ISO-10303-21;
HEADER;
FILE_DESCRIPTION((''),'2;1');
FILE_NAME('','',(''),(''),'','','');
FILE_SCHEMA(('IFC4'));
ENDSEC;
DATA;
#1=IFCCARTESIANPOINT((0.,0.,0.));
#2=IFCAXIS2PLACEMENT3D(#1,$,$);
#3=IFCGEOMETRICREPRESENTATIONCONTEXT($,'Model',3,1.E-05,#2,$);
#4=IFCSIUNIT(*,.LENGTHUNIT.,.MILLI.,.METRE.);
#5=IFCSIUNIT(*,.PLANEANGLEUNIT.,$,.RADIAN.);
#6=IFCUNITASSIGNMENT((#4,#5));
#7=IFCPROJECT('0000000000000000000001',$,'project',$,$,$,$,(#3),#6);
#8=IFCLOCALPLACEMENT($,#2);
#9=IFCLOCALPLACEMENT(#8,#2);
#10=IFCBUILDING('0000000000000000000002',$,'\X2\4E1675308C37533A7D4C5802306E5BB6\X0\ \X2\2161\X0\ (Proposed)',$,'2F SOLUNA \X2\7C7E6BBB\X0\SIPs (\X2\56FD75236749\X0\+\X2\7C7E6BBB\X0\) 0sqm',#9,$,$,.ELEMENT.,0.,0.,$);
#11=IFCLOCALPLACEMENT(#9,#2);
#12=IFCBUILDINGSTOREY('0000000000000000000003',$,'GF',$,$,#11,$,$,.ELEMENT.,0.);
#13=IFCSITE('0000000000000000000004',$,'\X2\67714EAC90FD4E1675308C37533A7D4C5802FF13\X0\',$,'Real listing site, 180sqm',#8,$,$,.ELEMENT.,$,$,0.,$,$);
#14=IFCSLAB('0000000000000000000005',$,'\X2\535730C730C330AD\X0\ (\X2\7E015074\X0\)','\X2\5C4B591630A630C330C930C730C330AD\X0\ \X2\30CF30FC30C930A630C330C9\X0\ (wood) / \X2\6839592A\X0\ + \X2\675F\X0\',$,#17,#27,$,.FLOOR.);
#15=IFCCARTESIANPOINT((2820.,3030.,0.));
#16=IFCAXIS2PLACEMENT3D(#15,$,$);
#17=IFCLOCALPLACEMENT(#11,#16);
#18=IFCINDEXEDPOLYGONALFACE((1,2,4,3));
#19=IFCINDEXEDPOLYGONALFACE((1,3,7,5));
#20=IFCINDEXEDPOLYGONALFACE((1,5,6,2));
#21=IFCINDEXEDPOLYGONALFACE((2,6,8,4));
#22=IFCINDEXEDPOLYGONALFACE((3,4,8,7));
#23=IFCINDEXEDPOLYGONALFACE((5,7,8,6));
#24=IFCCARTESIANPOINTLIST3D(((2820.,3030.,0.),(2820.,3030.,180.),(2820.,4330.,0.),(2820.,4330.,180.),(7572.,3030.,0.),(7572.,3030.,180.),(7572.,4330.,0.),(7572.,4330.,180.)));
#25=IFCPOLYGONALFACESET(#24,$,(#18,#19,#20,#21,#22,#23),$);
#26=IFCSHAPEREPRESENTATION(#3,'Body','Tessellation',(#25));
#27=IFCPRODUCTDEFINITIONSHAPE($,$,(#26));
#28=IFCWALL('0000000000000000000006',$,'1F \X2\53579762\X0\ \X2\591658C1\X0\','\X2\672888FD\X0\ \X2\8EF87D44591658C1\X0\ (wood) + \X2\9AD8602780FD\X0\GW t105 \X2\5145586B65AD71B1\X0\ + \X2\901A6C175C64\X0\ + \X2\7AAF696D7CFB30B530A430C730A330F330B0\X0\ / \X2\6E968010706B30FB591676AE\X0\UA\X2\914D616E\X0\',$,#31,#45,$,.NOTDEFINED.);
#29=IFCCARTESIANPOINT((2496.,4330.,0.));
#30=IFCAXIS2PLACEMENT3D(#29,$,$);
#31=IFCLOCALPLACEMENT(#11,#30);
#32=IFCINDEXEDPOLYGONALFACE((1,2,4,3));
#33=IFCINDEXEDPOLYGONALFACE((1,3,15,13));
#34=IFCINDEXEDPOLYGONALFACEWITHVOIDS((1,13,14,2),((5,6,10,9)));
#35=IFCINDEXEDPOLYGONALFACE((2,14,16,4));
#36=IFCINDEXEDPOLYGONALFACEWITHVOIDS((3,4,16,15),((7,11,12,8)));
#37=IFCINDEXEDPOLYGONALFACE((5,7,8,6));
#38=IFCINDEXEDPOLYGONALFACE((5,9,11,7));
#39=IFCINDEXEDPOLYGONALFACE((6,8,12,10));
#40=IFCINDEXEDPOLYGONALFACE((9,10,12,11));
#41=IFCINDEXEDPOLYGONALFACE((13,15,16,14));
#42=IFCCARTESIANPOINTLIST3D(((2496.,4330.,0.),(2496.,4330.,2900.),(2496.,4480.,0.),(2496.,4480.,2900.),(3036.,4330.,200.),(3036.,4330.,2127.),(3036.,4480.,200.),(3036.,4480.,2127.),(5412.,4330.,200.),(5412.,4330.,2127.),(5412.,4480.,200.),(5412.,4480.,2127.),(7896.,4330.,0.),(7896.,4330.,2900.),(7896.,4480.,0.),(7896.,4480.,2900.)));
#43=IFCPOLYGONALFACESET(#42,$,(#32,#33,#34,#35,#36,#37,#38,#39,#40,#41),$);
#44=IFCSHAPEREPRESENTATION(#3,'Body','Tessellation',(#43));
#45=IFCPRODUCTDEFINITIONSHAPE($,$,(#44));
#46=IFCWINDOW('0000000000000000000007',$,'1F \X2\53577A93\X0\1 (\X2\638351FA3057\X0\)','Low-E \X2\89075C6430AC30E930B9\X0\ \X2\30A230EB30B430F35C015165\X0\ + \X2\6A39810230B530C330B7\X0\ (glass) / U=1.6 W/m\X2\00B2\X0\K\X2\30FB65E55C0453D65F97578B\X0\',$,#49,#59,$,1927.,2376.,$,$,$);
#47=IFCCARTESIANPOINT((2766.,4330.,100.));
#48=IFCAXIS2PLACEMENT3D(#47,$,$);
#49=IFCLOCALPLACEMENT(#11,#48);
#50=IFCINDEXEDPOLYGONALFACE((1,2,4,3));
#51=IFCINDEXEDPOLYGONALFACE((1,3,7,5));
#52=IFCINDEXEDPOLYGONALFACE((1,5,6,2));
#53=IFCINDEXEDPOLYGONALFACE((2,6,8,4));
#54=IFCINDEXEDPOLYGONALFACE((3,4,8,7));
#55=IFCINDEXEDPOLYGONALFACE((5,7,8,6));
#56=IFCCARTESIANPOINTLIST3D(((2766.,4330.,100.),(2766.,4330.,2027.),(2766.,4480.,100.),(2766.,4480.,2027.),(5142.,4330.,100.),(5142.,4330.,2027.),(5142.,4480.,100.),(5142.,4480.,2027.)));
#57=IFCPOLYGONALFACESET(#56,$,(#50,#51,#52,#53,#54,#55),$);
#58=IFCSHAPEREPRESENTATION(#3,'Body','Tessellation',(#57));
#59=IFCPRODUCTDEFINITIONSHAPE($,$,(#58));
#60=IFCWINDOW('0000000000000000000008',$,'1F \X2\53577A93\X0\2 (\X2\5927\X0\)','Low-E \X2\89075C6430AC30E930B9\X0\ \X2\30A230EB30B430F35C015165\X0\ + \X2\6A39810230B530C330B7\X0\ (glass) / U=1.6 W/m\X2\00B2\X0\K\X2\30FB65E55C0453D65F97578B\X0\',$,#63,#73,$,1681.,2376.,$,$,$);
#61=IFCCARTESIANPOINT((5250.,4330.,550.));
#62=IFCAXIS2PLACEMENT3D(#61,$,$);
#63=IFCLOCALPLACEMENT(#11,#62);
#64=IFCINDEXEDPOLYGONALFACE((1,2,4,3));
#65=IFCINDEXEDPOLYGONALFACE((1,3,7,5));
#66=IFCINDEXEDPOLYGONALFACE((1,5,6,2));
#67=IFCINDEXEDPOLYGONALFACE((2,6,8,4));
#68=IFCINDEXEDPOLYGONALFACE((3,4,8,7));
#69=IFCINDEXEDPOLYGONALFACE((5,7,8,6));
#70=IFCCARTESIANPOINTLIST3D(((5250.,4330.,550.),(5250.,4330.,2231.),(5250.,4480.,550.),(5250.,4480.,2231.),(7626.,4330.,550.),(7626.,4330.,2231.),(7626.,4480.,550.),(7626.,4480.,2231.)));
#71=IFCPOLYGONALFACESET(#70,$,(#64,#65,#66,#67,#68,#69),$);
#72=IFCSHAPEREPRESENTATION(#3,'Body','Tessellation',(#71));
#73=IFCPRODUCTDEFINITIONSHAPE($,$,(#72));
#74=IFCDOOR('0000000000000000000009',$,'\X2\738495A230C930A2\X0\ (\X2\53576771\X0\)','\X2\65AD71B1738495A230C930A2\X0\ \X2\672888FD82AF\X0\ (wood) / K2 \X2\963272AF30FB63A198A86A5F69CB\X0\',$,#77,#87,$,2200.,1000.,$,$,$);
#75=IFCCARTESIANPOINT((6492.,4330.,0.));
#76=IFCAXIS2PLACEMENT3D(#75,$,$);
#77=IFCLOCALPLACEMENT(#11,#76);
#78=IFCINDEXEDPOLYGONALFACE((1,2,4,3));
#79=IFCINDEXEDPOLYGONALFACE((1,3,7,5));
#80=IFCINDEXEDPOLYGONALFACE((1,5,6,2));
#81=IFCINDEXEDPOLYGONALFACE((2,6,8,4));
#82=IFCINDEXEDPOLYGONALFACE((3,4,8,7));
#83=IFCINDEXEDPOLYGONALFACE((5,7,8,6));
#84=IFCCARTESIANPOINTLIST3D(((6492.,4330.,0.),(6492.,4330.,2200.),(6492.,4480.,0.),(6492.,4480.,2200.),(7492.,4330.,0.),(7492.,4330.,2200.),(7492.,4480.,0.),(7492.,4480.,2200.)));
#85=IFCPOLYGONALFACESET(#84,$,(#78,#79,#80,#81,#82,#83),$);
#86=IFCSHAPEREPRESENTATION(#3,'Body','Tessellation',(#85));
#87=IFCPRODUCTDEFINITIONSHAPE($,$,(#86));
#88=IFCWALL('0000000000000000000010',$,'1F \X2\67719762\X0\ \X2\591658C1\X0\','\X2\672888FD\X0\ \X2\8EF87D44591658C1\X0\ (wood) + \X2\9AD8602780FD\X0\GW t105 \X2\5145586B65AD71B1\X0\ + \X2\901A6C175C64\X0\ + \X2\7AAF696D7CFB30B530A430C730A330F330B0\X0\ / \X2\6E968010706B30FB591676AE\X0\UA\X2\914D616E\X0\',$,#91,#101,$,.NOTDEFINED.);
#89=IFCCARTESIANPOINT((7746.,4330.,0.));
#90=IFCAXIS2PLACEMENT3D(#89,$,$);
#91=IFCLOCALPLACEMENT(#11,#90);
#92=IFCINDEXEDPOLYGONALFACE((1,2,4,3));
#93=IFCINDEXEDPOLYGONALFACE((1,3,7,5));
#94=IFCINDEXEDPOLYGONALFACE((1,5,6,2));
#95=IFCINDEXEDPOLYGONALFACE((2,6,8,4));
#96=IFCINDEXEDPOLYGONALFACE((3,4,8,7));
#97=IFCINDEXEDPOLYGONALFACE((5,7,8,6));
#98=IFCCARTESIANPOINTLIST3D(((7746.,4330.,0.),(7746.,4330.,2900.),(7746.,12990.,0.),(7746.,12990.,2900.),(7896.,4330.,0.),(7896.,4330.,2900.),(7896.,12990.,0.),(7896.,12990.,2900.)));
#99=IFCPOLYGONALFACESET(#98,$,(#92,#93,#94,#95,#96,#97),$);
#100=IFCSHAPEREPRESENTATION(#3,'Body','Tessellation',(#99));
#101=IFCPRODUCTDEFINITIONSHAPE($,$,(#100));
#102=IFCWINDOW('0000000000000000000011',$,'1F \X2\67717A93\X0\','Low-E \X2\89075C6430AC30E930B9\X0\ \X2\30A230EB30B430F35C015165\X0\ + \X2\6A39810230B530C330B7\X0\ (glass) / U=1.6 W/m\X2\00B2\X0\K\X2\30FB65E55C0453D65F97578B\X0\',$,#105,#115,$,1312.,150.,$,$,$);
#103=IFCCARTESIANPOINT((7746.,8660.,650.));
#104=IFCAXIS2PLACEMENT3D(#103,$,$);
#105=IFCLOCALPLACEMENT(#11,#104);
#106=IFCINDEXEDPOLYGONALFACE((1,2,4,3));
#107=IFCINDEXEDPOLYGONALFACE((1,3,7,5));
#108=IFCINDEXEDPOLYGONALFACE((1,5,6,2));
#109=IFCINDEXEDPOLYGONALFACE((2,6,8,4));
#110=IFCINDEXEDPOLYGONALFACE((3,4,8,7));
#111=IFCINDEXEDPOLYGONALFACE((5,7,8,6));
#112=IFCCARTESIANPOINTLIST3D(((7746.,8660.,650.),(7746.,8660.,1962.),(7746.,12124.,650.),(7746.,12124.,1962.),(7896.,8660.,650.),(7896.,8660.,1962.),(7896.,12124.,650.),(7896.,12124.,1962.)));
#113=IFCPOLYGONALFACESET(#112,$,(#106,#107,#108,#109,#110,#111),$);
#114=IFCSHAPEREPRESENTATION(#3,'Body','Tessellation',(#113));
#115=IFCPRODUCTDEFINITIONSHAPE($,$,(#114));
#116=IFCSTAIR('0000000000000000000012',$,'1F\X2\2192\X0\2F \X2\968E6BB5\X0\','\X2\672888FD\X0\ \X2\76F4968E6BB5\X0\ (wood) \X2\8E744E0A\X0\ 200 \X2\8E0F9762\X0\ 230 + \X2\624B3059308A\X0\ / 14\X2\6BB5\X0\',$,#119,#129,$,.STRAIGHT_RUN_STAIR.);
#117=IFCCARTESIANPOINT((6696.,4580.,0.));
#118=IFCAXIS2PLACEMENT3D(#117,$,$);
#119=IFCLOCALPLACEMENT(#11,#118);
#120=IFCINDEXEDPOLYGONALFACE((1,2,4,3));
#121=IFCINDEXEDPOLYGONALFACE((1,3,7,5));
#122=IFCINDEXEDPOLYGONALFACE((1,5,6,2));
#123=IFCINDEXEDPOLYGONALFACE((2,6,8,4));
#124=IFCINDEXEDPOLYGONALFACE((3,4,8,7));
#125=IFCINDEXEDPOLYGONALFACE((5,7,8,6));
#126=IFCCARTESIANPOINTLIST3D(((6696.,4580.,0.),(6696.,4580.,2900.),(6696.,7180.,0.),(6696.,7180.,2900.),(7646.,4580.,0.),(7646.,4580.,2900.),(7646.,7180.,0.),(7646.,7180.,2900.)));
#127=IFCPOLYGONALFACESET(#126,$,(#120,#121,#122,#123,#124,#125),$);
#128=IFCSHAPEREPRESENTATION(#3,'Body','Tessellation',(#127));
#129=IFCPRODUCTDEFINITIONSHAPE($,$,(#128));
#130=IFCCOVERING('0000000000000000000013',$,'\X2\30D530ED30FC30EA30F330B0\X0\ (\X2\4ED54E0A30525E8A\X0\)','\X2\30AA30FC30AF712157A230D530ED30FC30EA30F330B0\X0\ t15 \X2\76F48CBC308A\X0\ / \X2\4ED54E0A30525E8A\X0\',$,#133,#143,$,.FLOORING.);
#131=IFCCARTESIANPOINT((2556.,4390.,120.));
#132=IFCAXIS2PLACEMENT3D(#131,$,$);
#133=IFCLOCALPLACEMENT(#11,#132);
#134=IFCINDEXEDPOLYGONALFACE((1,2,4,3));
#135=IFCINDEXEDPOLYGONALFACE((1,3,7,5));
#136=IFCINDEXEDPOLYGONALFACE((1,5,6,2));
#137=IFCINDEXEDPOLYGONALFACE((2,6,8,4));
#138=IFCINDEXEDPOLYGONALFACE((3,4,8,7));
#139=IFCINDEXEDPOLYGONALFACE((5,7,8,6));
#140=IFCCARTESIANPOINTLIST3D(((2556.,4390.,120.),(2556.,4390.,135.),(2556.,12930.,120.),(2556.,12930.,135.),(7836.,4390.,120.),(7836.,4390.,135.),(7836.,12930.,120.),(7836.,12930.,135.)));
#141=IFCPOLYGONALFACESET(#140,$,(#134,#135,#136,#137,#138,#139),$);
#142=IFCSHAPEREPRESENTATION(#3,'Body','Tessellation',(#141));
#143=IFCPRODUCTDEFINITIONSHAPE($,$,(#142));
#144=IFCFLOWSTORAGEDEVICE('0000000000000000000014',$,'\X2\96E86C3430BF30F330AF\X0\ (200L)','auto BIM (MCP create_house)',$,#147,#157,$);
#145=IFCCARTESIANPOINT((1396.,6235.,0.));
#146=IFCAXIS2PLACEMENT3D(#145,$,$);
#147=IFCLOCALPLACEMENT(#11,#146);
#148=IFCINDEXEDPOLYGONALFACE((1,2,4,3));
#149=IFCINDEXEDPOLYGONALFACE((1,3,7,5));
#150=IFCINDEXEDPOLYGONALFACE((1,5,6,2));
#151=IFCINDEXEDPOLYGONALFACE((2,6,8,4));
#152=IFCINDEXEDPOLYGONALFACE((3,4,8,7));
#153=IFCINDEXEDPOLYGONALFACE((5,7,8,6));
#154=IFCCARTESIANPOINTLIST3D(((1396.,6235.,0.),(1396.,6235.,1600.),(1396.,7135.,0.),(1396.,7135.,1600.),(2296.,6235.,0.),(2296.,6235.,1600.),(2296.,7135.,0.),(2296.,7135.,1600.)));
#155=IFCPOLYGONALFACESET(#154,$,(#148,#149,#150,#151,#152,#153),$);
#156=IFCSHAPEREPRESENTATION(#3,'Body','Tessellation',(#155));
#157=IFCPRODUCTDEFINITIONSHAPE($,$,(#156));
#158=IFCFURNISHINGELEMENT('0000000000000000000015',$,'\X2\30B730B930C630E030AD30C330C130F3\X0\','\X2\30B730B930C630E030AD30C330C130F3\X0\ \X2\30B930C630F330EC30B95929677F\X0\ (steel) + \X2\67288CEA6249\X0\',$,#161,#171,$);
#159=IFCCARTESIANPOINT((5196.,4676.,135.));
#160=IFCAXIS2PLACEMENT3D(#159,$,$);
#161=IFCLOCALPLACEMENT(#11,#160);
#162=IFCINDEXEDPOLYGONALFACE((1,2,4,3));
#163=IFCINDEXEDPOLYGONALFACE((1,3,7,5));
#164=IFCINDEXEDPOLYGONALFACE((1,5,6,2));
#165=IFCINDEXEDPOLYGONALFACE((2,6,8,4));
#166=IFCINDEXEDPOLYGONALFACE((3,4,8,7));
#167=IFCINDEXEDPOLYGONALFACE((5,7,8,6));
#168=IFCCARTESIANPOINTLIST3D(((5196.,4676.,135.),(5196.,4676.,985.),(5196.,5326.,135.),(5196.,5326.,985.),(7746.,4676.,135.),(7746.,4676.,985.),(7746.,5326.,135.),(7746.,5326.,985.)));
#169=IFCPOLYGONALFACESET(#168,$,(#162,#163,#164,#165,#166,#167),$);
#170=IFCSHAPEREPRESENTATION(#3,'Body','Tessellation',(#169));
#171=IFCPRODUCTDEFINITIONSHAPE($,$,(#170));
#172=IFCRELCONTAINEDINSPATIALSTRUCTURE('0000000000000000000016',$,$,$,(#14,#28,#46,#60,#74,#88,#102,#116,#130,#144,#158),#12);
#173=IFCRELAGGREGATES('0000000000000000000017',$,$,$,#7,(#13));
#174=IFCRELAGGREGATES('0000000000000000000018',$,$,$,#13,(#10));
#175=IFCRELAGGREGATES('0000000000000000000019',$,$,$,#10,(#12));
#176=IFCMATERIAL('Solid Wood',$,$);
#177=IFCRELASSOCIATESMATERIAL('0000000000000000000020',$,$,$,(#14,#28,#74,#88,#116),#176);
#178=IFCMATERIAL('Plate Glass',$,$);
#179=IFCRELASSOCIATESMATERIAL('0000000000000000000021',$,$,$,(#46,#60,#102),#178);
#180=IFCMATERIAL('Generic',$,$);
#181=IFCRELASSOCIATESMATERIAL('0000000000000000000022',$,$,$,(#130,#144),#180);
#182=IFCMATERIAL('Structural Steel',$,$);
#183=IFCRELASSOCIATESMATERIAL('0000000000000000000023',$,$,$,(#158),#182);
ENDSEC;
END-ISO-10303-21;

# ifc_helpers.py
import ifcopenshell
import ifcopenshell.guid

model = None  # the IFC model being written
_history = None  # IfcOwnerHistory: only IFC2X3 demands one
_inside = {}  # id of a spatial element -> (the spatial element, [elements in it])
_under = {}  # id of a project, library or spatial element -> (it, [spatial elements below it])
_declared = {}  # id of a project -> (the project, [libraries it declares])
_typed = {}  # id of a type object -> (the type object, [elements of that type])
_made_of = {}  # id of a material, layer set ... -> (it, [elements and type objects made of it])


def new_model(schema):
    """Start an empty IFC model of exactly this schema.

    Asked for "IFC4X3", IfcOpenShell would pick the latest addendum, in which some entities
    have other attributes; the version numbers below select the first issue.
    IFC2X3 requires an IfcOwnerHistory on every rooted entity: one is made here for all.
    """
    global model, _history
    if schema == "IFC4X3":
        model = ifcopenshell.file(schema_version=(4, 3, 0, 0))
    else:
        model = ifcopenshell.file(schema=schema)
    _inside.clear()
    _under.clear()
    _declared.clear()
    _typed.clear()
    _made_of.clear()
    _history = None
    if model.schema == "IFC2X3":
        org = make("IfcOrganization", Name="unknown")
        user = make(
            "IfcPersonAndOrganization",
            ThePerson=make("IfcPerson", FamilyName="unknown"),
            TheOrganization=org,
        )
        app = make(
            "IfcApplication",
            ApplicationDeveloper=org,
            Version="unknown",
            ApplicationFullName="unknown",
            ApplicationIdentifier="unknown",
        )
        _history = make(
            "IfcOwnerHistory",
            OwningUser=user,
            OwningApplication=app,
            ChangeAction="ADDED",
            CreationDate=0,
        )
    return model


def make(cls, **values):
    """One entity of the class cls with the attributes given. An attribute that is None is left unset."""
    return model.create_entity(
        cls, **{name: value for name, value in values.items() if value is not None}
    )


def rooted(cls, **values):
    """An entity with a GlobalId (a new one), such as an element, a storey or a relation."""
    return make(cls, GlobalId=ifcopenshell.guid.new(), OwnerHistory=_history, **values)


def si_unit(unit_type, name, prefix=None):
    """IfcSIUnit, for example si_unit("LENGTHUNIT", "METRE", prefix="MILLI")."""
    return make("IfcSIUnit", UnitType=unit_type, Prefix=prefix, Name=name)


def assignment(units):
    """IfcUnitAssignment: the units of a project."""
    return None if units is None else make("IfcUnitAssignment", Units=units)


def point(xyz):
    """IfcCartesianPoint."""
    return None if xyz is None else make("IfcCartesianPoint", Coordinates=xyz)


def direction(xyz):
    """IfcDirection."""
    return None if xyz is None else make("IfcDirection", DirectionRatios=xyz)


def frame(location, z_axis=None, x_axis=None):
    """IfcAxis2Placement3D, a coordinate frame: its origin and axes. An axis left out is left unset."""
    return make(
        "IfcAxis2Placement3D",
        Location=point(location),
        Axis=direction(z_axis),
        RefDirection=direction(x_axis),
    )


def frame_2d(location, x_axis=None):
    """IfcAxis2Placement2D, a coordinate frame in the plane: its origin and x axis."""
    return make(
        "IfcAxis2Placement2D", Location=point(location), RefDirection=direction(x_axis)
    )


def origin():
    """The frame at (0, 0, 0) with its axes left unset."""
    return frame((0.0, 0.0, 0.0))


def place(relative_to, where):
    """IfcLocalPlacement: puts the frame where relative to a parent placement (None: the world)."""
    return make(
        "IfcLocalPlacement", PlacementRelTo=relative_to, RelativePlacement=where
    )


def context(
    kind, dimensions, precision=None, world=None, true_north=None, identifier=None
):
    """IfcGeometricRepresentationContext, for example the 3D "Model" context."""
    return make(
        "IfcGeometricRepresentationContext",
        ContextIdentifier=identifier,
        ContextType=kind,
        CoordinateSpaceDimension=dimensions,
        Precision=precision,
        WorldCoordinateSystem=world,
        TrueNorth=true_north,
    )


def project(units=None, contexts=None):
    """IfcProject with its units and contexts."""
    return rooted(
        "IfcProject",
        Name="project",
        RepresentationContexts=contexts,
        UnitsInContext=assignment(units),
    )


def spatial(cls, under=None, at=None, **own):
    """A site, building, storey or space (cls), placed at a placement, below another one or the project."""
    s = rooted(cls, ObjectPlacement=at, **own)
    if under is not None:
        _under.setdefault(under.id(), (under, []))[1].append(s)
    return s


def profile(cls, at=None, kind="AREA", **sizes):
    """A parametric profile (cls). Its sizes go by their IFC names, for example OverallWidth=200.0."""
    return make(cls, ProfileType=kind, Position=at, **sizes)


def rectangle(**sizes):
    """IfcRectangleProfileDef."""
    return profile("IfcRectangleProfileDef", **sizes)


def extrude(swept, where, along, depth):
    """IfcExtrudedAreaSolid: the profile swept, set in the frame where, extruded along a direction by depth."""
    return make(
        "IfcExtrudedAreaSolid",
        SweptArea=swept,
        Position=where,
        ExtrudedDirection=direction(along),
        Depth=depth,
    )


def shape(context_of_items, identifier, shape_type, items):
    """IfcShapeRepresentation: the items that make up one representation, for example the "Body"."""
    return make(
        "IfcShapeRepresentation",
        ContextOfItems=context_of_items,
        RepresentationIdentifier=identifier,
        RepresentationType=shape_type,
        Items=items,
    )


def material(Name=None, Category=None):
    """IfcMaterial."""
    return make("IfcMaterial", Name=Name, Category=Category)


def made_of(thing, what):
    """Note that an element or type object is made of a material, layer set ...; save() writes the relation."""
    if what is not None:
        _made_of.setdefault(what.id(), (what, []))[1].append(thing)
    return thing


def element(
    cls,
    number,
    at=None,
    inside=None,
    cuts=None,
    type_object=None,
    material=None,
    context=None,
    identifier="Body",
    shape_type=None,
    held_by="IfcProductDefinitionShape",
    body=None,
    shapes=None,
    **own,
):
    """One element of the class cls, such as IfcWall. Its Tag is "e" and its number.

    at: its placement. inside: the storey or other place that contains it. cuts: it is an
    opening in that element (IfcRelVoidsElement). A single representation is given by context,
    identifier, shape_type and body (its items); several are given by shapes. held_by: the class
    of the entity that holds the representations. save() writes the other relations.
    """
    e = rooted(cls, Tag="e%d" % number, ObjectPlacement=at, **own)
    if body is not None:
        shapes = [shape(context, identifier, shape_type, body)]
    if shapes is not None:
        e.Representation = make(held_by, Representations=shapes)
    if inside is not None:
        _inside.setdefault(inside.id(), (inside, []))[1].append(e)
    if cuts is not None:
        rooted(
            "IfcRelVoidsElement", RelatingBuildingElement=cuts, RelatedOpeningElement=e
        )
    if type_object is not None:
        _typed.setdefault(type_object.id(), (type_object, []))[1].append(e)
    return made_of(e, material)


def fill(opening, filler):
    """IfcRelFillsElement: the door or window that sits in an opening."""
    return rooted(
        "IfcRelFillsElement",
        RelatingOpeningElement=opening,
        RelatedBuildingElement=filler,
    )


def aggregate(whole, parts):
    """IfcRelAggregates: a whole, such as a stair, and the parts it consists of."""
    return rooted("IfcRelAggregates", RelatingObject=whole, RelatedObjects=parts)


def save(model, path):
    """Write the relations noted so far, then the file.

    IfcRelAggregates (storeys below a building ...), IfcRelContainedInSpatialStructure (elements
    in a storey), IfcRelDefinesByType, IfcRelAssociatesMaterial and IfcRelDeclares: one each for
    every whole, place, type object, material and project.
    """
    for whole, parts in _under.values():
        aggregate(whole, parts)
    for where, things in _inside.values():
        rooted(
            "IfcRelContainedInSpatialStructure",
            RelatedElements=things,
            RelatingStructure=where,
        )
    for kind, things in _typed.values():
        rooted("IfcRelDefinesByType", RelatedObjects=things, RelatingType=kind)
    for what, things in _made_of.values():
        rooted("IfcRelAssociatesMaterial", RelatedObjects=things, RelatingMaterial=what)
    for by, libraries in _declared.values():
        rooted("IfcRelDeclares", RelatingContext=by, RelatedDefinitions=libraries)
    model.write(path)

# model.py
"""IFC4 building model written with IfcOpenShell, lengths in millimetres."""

from ifc_helpers import new_model, si_unit, frame, frame_2d, origin, place, context, project, spatial, rectangle, extrude, material, element, fill, save


model = new_model("IFC4")

# Units and contexts
model_context = context("Model", 3, precision=1e-05, world=origin())
ifc_project = project(units=[si_unit("LENGTHUNIT", "METRE", prefix="MILLI"), si_unit("PLANEANGLEUNIT", "RADIAN")], contexts=[model_context])

# Site, building, storey
site_placement = place(None, origin())
site = spatial("IfcSite", under=ifc_project, at=site_placement, Name="東京都世田谷区経堂３", ObjectType="Real listing site, 180sqm", CompositionType="ELEMENT", RefElevation=0.0)
building_placement = place(site_placement, origin())
building = spatial("IfcBuilding", under=site, at=building_placement, Name="世田谷区経堂の家 Ⅱ (Proposed)", ObjectType="2F SOLUNA 籾殻SIPs (国産杉+籾殻) 0sqm", CompositionType="ELEMENT", ElevationOfRefHeight=0.0, ElevationOfTerrain=0.0)
storey_placement = place(building_placement, origin())
storey = spatial("IfcBuildingStorey", under=building, at=storey_placement, Name="GF", CompositionType="ELEMENT", Elevation=0.0)

# Slab
ifc_material_1 = material(Name="Solid Wood")
slab_1_placement = place(storey_placement, frame((2820.0, 3030.0, 0.0)))
element("IfcSlab", 1, at=slab_1_placement, inside=storey, material=ifc_material_1, Name="南デッキ (縁側)", Description="屋外ウッドデッキ ハードウッド (wood) / 根太 + 束", PredefinedType="FLOOR", context=model_context, shape_type="SweptSolid", body=[
    extrude(rectangle(XDim=4752.0, YDim=1300.0, at=frame_2d((2376.0, 650.0))), frame((2820.0, 3030.0, 0.0)), (0.0, 0.0, 1.0), 180.0),
])

# Wall, openings, windows, door
wall_1_placement = place(storey_placement, frame((2496.0, 4330.0, 0.0)))
wall_1 = element("IfcWall", 2, at=wall_1_placement, inside=storey, material=ifc_material_1, Name="1F 南面 外壁", Description="木製 軸組外壁 (wood) + 高性能GW t105 充填断熱 + 通気層 + 窯業系サイディング / 準耐火・外皮UA配慮", PredefinedType="NOTDEFINED", context=model_context, shape_type="SweptSolid", body=[
    extrude(rectangle(XDim=5400.0, YDim=150.0, at=frame_2d((2700.0, 75.0))), frame((2496.0, 4330.0, 0.0)), (0.0, 0.0, 1.0), 2900.0),
])
opening_1_placement = place(storey_placement, frame((2766.0, 4330.0, 100.0)))
opening_1 = element("IfcOpeningElement", 3, at=opening_1_placement, cuts=wall_1, PredefinedType="NOTDEFINED", context=model_context, shape_type="SweptSolid", body=[
    extrude(rectangle(XDim=2376.0, YDim=150.0, at=frame_2d((1188.0, 75.0))), frame((2766.0, 4330.0, 100.0)), (0.0, 0.0, 1.0), 1927.0),
])
opening_2_placement = place(storey_placement, frame((5250.0, 4330.0, 550.0)))
opening_2 = element("IfcOpeningElement", 4, at=opening_2_placement, cuts=wall_1, PredefinedType="NOTDEFINED", context=model_context, shape_type="SweptSolid", body=[
    extrude(rectangle(XDim=2376.0, YDim=150.0, at=frame_2d((1188.0, 75.0))), frame((5250.0, 4330.0, 550.0)), (0.0, 0.0, 1.0), 1681.0),
])
opening_3_placement = place(storey_placement, frame((6492.0, 4330.0, 0.0)))
opening_3 = element("IfcOpeningElement", 5, at=opening_3_placement, cuts=wall_1, PredefinedType="NOTDEFINED", context=model_context, shape_type="SweptSolid", body=[
    extrude(rectangle(XDim=1000.0, YDim=150.0, at=frame_2d((500.0, 75.0))), frame((6492.0, 4330.0, 0.0)), (0.0, 0.0, 1.0), 2200.0),
])
ifc_material_2 = material(Name="Plate Glass")
window_1_placement = place(storey_placement, frame((2766.0, 4330.0, 100.0)))
window_1 = element("IfcWindow", 6, at=window_1_placement, inside=storey, material=ifc_material_2, Name="1F 南窓1 (掃出し)", Description="Low-E 複層ガラス アルゴン封入 + 樹脂サッシ (glass) / U=1.6 W/m²K・日射取得型", OverallHeight=1927.0, OverallWidth=2376.0, context=model_context, shape_type="SweptSolid", body=[
    extrude(rectangle(XDim=2376.0, YDim=150.0, at=frame_2d((1188.0, 75.0))), frame((2766.0, 4330.0, 100.0)), (0.0, 0.0, 1.0), 1927.0),
])
fill(opening_1, window_1)
window_2_placement = place(storey_placement, frame((5250.0, 4330.0, 550.0)))
window_2 = element("IfcWindow", 7, at=window_2_placement, inside=storey, material=ifc_material_2, Name="1F 南窓2 (大)", Description="Low-E 複層ガラス アルゴン封入 + 樹脂サッシ (glass) / U=1.6 W/m²K・日射取得型", OverallHeight=1681.0, OverallWidth=2376.0, context=model_context, shape_type="SweptSolid", body=[
    extrude(rectangle(XDim=2376.0, YDim=150.0, at=frame_2d((1188.0, 75.0))), frame((5250.0, 4330.0, 550.0)), (0.0, 0.0, 1.0), 1681.0),
])
fill(opening_2, window_2)
door_placement = place(storey_placement, frame((6492.0, 4330.0, 0.0)))
door = element("IfcDoor", 8, at=door_placement, inside=storey, material=ifc_material_1, Name="玄関ドア (南東)", Description="断熱玄関ドア 木製芯 (wood) / K2 防犯・採風機構", OverallHeight=2200.0, OverallWidth=1000.0, context=model_context, shape_type="SweptSolid", body=[
    extrude(rectangle(XDim=1000.0, YDim=150.0, at=frame_2d((500.0, 75.0))), frame((6492.0, 4330.0, 0.0)), (0.0, 0.0, 1.0), 2200.0),
])
fill(opening_3, door)

# Wall, opening, window
wall_2_placement = place(storey_placement, frame((7746.0, 4330.0, 0.0)))
wall_2 = element("IfcWall", 9, at=wall_2_placement, inside=storey, material=ifc_material_1, Name="1F 東面 外壁", Description="木製 軸組外壁 (wood) + 高性能GW t105 充填断熱 + 通気層 + 窯業系サイディング / 準耐火・外皮UA配慮", PredefinedType="NOTDEFINED", context=model_context, shape_type="SweptSolid", body=[
    extrude(rectangle(XDim=150.0, YDim=8660.0, at=frame_2d((75.0, 4330.0))), frame((7746.0, 4330.0, 0.0)), (0.0, 0.0, 1.0), 2900.0),
])
opening_4_placement = place(storey_placement, frame((7746.0, 8660.0, 650.0)))
opening_4 = element("IfcOpeningElement", 10, at=opening_4_placement, cuts=wall_2, PredefinedType="NOTDEFINED", context=model_context, shape_type="SweptSolid", body=[
    extrude(rectangle(XDim=150.0, YDim=3464.0, at=frame_2d((75.0, 1732.0))), frame((7746.0, 8660.0, 650.0)), (0.0, 0.0, 1.0), 1312.0),
])
window_3_placement = place(storey_placement, frame((7746.0, 8660.0, 650.0)))
window_3 = element("IfcWindow", 11, at=window_3_placement, inside=storey, material=ifc_material_2, Name="1F 東窓", Description="Low-E 複層ガラス アルゴン封入 + 樹脂サッシ (glass) / U=1.6 W/m²K・日射取得型", OverallHeight=1312.0, OverallWidth=150.0, context=model_context, shape_type="SweptSolid", body=[
    extrude(rectangle(XDim=150.0, YDim=3464.0, at=frame_2d((75.0, 1732.0))), frame((7746.0, 8660.0, 650.0)), (0.0, 0.0, 1.0), 1312.0),
])
fill(opening_4, window_3)

# Stair
stair_placement = place(storey_placement, frame((6696.0, 4580.0, 0.0)))
element("IfcStair", 12, at=stair_placement, inside=storey, material=ifc_material_1, Name="1F→2F 階段", Description="木製 直階段 (wood) 蹴上 200 踏面 230 + 手すり / 14段", PredefinedType="STRAIGHT_RUN_STAIR", context=model_context, shape_type="SweptSolid", body=[
    extrude(rectangle(XDim=950.0, YDim=2600.0, at=frame_2d((475.0, 1300.0))), frame((6696.0, 4580.0, 0.0)), (0.0, 0.0, 1.0), 2900.0),
])

# Covering
ifc_material_3 = material(Name="Generic")
covering_placement = place(storey_placement, frame((2556.0, 4390.0, 120.0)))
element("IfcCovering", 13, at=covering_placement, inside=storey, material=ifc_material_3, Name="フローリング (仕上げ床)", Description="オーク無垢フローリング t15 直貼り / 仕上げ床", PredefinedType="FLOORING", context=model_context, shape_type="SweptSolid", body=[
    extrude(rectangle(XDim=5280.0, YDim=8540.0, at=frame_2d((2640.0, 4270.0))), frame((2556.0, 4390.0, 120.0)), (0.0, 0.0, 1.0), 15.0),
])

# Flow storage device
flow_storage_device_placement = place(storey_placement, frame((1396.0, 6235.0, 0.0)))
element("IfcFlowStorageDevice", 14, at=flow_storage_device_placement, inside=storey, material=ifc_material_3, Name="雨水タンク (200L)", Description="auto BIM (MCP create_house)", context=model_context, shape_type="SweptSolid", body=[
    extrude(rectangle(XDim=900.0, YDim=900.0, at=frame_2d((450.0, 450.0))), frame((1396.0, 6235.0, 0.0)), (0.0, 0.0, 1.0), 1600.0),
])

# Furnishing element
ifc_material_4 = material(Name="Structural Steel")
furnishing_placement = place(storey_placement, frame((5196.0, 4676.0, 135.0)))
element("IfcFurnishingElement", 15, at=furnishing_placement, inside=storey, material=ifc_material_4, Name="システムキッチン", Description="システムキッチン ステンレス天板 (steel) + 木質扉", context=model_context, shape_type="SweptSolid", body=[
    extrude(rectangle(XDim=2550.0, YDim=650.0, at=frame_2d((1275.0, 325.0))), frame((5196.0, 4676.0, 135.0)), (0.0, 0.0, 1.0), 850.0),
])

save(model, "model.ifc")
